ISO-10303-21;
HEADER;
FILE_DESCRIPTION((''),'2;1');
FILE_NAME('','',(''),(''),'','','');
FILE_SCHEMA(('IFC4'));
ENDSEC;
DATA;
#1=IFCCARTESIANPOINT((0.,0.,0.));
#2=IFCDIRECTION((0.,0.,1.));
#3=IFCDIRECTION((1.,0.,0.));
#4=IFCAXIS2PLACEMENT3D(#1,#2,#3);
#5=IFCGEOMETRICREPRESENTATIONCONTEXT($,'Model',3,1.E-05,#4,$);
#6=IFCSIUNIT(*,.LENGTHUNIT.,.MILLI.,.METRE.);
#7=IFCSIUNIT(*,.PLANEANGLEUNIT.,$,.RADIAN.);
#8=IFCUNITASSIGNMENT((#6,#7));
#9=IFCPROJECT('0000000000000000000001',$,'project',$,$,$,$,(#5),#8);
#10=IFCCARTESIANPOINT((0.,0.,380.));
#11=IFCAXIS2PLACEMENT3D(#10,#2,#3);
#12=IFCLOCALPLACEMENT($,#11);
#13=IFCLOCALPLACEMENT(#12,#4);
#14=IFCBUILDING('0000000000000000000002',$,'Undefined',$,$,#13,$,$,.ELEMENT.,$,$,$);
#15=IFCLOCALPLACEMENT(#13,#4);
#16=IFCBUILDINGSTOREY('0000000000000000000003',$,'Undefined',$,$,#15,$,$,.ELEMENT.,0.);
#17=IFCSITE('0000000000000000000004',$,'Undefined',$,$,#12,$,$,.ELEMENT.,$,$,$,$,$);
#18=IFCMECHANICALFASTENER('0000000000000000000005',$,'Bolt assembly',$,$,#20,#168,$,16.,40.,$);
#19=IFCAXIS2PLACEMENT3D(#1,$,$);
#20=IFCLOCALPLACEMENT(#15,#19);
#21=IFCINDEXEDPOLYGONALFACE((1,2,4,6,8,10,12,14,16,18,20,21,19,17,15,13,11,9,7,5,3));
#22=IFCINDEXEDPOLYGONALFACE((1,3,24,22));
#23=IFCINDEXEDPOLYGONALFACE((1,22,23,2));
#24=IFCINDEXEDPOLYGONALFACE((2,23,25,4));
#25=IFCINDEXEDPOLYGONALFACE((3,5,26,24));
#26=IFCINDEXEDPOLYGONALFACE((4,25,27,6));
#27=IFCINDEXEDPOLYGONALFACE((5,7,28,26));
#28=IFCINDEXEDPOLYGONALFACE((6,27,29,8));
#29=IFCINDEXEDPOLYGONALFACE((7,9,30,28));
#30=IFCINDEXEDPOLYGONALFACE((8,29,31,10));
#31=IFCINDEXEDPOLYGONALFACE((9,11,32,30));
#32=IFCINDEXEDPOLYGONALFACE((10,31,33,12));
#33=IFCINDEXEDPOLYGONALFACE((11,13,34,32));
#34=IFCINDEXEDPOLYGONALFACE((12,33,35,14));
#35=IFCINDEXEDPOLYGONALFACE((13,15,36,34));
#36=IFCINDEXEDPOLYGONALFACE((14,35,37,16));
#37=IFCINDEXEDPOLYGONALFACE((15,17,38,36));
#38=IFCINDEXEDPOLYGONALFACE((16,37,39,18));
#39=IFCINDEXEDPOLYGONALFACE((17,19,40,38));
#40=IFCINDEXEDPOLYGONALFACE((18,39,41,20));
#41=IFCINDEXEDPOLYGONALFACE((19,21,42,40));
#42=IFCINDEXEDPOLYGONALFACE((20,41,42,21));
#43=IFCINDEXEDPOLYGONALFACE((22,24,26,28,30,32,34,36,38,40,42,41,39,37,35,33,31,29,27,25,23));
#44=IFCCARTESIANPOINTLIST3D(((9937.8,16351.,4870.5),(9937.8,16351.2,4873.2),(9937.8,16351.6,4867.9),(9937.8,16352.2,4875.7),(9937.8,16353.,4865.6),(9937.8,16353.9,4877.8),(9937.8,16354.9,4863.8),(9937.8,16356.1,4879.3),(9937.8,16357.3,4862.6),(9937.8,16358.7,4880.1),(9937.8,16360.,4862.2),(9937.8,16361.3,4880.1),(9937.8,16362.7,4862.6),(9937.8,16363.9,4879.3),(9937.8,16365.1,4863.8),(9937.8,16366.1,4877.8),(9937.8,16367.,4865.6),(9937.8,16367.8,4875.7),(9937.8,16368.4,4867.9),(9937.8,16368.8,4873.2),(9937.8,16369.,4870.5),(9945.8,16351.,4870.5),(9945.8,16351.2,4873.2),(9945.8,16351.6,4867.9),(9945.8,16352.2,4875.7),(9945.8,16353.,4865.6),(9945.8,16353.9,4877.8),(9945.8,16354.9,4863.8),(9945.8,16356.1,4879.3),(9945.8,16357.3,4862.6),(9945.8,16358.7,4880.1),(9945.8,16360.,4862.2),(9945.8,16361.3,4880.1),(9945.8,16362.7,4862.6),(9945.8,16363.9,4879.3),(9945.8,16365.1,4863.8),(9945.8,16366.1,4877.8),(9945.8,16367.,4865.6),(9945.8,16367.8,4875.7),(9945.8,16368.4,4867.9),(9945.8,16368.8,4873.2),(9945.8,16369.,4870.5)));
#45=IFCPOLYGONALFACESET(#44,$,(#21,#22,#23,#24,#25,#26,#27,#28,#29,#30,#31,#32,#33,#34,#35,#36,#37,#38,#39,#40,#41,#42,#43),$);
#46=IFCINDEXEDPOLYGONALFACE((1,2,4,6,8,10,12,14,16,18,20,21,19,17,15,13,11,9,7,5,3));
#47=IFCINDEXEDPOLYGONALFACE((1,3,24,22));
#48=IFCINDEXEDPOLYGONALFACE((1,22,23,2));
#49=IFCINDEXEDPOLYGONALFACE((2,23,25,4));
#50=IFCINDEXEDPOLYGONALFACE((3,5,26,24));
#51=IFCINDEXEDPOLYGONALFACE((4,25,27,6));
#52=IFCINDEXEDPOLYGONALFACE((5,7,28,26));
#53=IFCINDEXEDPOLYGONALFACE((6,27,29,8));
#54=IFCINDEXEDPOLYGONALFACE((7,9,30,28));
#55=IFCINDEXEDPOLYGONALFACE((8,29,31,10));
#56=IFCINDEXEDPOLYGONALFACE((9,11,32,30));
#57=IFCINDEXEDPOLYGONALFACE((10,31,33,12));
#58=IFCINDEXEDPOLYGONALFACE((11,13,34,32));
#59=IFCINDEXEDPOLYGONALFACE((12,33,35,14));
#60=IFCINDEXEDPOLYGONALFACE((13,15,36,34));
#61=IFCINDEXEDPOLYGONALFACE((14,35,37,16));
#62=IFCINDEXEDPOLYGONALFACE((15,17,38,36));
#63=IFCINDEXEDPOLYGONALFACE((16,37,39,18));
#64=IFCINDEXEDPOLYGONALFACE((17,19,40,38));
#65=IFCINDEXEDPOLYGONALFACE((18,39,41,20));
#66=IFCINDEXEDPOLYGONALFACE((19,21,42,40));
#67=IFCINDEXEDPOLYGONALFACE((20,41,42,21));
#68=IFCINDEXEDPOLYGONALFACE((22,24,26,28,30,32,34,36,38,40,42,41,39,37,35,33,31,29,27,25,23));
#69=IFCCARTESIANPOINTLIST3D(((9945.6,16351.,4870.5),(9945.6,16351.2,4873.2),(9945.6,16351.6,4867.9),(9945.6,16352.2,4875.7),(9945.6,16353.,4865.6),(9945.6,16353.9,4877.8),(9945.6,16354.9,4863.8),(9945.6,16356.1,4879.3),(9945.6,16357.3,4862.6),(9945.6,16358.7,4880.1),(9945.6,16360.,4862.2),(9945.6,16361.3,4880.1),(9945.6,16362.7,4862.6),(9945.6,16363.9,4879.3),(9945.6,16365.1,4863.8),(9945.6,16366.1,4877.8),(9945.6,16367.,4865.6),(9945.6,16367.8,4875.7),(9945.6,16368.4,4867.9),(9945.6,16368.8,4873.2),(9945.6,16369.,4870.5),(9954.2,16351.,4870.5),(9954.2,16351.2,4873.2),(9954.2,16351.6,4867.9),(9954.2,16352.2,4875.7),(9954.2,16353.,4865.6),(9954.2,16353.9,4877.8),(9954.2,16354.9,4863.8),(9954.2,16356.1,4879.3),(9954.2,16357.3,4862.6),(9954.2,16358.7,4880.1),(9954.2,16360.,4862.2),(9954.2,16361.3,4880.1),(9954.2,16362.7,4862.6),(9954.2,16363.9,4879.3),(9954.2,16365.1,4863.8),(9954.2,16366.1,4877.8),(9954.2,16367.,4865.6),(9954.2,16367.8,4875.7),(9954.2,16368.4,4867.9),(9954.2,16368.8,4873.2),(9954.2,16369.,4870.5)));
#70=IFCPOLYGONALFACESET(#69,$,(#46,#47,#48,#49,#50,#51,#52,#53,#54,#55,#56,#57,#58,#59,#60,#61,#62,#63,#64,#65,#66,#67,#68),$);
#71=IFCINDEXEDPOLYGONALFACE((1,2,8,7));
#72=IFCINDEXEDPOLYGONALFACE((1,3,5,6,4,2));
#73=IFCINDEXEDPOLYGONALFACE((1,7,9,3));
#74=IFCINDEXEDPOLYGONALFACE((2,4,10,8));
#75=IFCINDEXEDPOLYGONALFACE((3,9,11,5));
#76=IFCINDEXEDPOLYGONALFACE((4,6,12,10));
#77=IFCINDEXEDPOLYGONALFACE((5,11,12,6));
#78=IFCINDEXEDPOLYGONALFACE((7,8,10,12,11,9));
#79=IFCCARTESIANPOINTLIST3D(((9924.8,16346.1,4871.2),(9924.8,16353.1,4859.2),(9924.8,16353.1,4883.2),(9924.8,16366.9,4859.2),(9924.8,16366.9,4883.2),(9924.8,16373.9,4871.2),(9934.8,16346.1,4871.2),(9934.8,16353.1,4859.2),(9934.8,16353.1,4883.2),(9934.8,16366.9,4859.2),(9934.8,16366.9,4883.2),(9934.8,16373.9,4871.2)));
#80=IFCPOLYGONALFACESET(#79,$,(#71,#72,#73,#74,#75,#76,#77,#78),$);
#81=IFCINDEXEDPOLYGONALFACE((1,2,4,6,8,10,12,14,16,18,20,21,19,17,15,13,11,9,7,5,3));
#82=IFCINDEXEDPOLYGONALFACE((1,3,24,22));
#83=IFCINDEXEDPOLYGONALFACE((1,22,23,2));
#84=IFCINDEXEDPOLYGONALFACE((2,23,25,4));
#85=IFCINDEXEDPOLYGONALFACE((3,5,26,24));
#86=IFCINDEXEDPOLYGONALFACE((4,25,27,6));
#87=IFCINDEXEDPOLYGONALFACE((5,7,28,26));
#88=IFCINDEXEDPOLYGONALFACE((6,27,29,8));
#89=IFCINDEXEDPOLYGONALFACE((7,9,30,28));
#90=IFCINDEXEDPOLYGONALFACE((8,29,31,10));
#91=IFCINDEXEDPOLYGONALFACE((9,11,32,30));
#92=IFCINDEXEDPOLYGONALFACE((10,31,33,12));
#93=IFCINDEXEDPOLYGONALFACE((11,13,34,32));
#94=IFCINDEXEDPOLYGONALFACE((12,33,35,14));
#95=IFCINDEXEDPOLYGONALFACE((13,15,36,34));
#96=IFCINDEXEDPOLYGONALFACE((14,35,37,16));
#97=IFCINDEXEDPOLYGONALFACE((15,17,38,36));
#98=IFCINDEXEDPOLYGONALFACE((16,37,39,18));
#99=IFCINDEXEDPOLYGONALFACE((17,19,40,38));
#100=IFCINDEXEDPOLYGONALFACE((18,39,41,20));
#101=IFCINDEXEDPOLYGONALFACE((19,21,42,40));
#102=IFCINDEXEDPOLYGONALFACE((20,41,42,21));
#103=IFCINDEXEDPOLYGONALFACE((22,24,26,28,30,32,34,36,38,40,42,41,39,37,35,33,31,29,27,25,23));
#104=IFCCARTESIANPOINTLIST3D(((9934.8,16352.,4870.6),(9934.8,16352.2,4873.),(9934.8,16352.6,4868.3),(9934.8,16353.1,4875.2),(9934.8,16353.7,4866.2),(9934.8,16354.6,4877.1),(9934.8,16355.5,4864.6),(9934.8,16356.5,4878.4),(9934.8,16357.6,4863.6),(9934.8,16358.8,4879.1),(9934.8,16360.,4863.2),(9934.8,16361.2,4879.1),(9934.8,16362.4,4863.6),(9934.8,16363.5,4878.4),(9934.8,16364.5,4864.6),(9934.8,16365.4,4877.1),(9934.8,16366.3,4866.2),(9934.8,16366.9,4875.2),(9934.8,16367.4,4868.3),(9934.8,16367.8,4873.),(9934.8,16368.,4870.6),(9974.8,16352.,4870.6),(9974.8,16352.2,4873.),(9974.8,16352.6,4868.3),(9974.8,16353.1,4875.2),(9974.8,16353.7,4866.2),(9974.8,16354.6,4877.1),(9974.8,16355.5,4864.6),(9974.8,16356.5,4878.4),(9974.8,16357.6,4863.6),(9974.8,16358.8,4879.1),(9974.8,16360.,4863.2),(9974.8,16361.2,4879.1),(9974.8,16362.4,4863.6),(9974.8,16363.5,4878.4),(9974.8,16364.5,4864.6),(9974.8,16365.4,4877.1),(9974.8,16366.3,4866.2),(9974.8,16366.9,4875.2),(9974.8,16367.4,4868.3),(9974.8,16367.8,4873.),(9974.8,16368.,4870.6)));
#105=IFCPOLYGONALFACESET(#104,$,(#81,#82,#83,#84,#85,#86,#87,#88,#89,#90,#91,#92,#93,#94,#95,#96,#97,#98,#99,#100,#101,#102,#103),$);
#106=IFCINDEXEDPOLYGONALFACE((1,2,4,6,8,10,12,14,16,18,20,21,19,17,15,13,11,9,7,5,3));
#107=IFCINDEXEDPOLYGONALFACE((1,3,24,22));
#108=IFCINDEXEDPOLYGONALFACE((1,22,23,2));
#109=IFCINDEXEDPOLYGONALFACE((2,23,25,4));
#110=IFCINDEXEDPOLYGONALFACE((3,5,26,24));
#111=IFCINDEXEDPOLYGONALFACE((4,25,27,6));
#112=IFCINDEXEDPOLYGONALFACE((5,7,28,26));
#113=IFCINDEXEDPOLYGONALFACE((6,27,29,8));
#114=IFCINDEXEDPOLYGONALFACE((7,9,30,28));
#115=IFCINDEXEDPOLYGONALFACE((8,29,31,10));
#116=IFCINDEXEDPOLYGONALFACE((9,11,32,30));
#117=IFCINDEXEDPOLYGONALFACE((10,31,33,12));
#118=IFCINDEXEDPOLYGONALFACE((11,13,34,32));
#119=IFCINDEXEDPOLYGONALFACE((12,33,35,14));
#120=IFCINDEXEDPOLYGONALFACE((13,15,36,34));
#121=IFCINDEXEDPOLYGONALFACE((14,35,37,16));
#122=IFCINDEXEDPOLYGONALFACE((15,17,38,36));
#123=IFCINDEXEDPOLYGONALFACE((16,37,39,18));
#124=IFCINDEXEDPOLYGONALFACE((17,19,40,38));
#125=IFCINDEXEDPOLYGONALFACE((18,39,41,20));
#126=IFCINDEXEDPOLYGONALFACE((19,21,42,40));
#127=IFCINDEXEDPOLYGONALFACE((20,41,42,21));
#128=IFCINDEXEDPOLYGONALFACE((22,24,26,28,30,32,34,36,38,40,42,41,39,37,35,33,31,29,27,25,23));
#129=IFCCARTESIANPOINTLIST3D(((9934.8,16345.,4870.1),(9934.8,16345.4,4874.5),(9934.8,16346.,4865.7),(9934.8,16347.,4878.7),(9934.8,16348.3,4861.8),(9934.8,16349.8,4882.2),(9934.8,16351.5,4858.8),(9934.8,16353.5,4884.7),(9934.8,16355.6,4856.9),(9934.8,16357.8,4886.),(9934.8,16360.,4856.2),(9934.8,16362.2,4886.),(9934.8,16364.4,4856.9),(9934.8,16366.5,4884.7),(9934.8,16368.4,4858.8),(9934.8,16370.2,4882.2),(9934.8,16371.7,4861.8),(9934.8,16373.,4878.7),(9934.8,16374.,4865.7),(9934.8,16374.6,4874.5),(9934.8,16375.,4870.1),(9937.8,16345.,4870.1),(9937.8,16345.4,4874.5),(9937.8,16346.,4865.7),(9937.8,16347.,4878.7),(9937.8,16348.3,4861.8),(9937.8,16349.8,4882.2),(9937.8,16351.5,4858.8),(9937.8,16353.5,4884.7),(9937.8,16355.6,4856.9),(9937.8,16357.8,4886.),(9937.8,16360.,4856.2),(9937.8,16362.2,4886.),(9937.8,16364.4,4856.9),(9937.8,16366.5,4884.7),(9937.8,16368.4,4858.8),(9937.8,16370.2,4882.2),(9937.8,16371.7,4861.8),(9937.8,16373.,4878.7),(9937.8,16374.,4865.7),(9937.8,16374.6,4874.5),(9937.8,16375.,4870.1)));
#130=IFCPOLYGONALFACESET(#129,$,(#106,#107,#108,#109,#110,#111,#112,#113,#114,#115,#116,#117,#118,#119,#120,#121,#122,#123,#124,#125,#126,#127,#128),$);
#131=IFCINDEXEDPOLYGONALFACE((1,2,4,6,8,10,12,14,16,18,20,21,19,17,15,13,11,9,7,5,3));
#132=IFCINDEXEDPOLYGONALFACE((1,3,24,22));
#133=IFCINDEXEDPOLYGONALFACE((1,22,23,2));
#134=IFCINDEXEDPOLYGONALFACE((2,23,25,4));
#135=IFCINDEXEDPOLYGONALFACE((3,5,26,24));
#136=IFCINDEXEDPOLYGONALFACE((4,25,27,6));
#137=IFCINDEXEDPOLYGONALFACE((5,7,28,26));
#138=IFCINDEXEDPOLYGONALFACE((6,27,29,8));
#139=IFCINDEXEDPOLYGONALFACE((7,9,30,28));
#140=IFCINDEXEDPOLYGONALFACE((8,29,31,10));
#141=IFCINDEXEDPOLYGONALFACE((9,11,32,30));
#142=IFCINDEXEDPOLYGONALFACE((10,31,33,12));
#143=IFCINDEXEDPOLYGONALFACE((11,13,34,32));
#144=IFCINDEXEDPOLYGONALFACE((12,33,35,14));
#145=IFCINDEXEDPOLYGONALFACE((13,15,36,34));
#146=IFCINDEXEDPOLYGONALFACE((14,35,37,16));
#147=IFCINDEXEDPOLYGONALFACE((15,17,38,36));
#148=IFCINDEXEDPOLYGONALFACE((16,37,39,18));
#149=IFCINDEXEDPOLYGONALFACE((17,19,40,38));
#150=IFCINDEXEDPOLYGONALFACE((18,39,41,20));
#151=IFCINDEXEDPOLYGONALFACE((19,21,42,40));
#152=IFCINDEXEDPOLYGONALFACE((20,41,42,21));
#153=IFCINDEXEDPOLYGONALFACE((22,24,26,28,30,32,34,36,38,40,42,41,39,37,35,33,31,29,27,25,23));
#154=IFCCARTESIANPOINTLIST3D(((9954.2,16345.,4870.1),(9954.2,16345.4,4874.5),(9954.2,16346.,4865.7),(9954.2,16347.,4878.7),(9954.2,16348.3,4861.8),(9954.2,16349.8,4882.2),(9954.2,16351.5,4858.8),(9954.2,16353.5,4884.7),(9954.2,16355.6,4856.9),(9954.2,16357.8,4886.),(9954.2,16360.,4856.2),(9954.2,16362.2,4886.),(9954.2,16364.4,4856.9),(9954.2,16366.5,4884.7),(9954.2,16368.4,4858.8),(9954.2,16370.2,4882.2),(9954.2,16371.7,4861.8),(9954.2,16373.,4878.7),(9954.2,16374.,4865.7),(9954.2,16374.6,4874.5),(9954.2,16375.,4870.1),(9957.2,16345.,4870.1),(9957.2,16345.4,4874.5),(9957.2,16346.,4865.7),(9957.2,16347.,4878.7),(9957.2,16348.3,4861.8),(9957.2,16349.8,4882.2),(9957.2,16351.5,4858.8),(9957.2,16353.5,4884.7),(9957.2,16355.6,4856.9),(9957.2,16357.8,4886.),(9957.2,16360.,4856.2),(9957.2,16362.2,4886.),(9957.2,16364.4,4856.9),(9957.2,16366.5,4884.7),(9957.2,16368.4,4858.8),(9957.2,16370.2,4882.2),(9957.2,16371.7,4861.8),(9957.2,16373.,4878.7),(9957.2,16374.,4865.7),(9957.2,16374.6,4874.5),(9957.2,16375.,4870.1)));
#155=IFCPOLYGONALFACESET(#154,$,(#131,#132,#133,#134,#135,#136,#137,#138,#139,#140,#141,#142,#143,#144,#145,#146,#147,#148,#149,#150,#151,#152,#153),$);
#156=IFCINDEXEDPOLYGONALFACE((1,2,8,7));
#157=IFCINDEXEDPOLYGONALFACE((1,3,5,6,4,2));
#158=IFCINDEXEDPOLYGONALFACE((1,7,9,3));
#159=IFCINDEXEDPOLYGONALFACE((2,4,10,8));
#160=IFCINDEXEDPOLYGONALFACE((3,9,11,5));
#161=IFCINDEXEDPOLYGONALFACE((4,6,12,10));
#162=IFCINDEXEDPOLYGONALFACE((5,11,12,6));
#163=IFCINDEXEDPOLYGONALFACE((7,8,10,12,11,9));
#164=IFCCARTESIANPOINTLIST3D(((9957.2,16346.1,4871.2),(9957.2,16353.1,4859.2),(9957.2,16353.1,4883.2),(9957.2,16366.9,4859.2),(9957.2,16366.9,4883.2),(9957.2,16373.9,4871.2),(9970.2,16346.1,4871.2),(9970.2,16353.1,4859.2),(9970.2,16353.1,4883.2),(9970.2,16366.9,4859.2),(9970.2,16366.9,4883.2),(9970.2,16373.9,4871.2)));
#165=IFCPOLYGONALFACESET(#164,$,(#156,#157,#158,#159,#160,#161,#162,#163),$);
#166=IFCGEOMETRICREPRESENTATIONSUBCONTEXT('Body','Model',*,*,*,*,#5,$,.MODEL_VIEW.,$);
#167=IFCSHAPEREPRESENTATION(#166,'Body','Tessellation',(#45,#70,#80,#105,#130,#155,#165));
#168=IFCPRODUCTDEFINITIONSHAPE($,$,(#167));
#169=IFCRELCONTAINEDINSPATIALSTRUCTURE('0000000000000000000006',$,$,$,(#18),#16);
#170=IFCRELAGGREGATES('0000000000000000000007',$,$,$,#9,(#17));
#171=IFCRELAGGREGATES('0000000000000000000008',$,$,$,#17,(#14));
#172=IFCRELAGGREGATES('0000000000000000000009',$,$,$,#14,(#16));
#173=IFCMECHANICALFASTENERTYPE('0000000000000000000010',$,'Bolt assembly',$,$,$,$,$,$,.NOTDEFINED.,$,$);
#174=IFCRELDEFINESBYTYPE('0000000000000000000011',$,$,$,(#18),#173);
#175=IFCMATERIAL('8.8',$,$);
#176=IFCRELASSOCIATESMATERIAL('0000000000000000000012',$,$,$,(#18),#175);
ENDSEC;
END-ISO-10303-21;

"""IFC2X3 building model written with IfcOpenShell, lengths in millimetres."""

from ifc_helpers import new_model, si_unit, frame, origin_with_axes, origin_2d_with_axis, place, context, subcontext, project, spatial, polyline, circle, outline, extrude, source, transform, mapped, material, type_object, element, save


model = new_model("IFC2X3")

# Units and contexts
model_context = context("Model", 3, precision=1e-05, world=origin_with_axes())
body_context = subcontext(model_context, "Body", "Model", "MODEL_VIEW")
ifc_project = project(units=[si_unit("LENGTHUNIT", "METRE", prefix="MILLI"), si_unit("PLANEANGLEUNIT", "RADIAN")], contexts=[model_context])

# Site, building, storey
site_placement = place(None, frame((0.0, 0.0, 380.0), z_axis=(0.0, 0.0, 1.0), x_axis=(1.0, 0.0, 0.0)))
site = spatial("IfcSite", under=ifc_project, at=site_placement, Name="Undefined", CompositionType="ELEMENT")
building_placement = place(site_placement, origin_with_axes())
building = spatial("IfcBuilding", under=site, at=building_placement, Name="Undefined", CompositionType="ELEMENT")
storey_placement = place(building_placement, origin_with_axes())
storey = spatial("IfcBuildingStorey", under=building, at=storey_placement, Name="Undefined", CompositionType="ELEMENT", Elevation=0.0)

# Mechanical fastener
ifc_material_1 = material(Name="8.8")
mechanical_fastener_type = type_object("IfcMechanicalFastenerType", Name="Bolt assembly")
shared_shape_1 = source(origin_with_axes(), body_context, "Body", "SweptSolid", [
    extrude(circle(Radius=9.0, at=origin_2d_with_axis()), frame((0.0, -7.9, 0.0), z_axis=(0.0, 1.0, 0.0), x_axis=(1.0, 0.0, 0.0)), (0.0, 0.0, 1.0), 8.0),
    extrude(circle(Radius=9.0, at=origin_2d_with_axis()), frame((0.0, -0.1, 0.0), z_axis=(0.0, 1.0, 0.0), x_axis=(1.0, 0.0, 0.0)), (0.0, 0.0, 1.0), 8.6),
    extrude(outline(polyline([(12.0, -6.9), (12.0, 6.9), (0.0, 13.9), (-12.0, 6.9), (-12.0, -6.9), (0.0, -13.9), (12.0, -6.9)])), frame((0.0, -21.0, 0.0), z_axis=(0.0, 1.0, 0.0), x_axis=(1.0, 0.0, 0.0)), (0.0, 0.0, 1.0), 10.0),
    extrude(circle(Radius=8.0, at=origin_2d_with_axis()), frame((0.0, -11.0, 0.0), z_axis=(0.0, 1.0, 0.0), x_axis=(1.0, 0.0, 0.0)), (0.0, 0.0, 1.0), 40.0),
    extrude(circle(Radius=15.0, at=origin_2d_with_axis()), frame((0.0, -11.0, 0.0), z_axis=(0.0, 1.0, 0.0), x_axis=(1.0, 0.0, 0.0)), (0.0, 0.0, 1.0), 3.0),
    extrude(circle(Radius=15.0, at=origin_2d_with_axis()), frame((0.0, 8.5, 0.0), z_axis=(0.0, 1.0, 0.0), x_axis=(1.0, 0.0, 0.0)), (0.0, 0.0, 1.0), 3.0),
    extrude(outline(polyline([(12.0, -6.9), (12.0, 6.9), (0.0, 13.9), (-12.0, 6.9), (-12.0, -6.9), (0.0, -13.9), (12.0, -6.9)])), frame((0.0, 11.5, 0.0), z_axis=(0.0, 1.0, 0.0), x_axis=(1.0, 0.0, 0.0)), (0.0, 0.0, 1.0), 13.0),
])
for number, where, z_axis, x_axis, name in (
    (1, (9945.8, 16397.5, 4951.2), (0.0, -1.0, 0.0), (0.0, 0.0, -1.0), "Bolt assembly"),
):
    element("IfcMechanicalFastener", number, at=place(storey_placement, frame(where, z_axis=z_axis, x_axis=x_axis)), inside=storey, type_object=mechanical_fastener_type, material=ifc_material_1, Name=name, NominalDiameter=16.0, NominalLength=40.0, context=body_context, shape_type="MappedRepresentation", body=[
        mapped(shared_shape_1, transform((80.0, 0.0, 37.5))),
    ])

save(model, "model.ifc")
